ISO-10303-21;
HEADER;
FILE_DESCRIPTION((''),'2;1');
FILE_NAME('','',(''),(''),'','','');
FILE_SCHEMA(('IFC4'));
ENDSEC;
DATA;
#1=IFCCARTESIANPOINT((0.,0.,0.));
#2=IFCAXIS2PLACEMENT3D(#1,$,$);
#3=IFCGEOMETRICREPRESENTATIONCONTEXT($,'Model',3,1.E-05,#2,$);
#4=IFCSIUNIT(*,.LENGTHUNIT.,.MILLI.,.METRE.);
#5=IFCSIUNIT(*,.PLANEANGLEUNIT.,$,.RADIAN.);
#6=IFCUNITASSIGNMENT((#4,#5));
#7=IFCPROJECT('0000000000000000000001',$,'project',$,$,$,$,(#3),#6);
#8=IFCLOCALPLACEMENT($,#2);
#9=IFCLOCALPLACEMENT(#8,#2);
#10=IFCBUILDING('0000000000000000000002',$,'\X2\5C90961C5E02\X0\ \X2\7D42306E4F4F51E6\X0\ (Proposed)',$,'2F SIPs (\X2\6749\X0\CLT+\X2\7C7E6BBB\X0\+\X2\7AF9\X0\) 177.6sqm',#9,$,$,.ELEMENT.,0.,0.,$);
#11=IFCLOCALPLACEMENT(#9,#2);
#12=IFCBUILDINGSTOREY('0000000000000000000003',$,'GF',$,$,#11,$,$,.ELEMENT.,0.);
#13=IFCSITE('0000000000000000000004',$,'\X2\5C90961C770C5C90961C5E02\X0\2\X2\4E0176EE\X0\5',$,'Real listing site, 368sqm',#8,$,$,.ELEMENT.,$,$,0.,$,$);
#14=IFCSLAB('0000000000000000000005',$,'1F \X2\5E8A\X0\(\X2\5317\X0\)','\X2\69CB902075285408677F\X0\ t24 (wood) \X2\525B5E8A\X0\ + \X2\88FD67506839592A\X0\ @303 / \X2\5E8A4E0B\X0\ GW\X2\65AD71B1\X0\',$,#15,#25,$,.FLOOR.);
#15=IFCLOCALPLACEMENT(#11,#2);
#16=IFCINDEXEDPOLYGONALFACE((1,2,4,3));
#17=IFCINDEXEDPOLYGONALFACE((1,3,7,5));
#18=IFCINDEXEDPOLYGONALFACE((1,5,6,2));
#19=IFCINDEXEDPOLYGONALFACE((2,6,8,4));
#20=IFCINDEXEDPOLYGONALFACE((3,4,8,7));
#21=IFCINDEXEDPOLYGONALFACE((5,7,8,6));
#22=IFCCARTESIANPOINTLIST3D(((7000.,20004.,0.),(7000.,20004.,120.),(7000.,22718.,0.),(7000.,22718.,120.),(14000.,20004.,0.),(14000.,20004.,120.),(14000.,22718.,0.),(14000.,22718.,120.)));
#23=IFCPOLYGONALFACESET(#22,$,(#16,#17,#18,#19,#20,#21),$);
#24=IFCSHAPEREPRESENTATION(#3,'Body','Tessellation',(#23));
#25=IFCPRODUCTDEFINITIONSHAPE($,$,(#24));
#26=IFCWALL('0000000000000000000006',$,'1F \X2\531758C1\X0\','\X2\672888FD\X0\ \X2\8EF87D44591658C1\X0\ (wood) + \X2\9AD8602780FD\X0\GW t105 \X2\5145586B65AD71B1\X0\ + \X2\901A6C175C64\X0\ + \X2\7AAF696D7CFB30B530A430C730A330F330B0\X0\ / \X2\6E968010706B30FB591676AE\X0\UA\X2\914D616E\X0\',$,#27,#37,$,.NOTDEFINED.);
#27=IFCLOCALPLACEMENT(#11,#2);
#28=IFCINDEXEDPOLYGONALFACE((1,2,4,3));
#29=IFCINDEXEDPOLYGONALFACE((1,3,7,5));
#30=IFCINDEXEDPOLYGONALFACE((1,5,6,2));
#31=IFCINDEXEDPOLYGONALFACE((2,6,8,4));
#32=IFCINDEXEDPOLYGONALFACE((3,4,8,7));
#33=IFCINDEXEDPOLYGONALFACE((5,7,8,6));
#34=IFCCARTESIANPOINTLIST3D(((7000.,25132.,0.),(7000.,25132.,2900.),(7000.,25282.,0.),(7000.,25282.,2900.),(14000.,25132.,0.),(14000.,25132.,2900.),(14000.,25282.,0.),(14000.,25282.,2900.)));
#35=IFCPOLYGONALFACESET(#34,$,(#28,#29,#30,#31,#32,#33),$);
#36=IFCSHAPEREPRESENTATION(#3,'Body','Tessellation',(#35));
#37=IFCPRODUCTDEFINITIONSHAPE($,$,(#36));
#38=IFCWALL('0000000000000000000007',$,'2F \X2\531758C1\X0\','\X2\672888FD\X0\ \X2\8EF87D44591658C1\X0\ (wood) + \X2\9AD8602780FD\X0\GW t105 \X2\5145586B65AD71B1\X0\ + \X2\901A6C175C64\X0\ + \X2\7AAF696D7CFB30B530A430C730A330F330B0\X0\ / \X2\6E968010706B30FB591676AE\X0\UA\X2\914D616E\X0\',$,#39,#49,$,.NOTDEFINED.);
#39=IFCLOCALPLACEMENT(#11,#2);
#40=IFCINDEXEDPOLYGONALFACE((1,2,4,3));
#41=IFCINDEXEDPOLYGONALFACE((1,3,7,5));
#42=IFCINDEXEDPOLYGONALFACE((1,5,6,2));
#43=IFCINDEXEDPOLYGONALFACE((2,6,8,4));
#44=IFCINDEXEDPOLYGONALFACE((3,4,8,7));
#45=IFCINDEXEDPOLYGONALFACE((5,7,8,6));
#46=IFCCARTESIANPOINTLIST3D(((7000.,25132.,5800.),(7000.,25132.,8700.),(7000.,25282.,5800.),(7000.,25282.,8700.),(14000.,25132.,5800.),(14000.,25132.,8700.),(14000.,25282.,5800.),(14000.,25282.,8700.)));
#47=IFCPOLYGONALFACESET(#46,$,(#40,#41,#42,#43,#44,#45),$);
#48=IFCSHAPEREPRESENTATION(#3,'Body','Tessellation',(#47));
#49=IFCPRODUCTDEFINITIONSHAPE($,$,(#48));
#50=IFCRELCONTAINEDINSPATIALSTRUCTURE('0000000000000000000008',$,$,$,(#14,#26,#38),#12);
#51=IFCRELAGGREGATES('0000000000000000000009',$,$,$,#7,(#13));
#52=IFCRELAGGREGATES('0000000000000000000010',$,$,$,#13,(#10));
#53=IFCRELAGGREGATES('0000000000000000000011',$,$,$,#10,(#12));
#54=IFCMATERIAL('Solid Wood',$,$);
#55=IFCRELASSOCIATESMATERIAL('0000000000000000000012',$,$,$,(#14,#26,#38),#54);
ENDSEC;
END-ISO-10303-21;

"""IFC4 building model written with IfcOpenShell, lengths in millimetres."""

from ifc_helpers import new_model, si_unit, frame, frame_2d, origin, place, context, project, spatial, rectangle, extrude, material, element, save


model = new_model("IFC4")

# Units and contexts
model_context = context("Model", 3, precision=1e-05, world=origin())
ifc_project = project(units=[si_unit("LENGTHUNIT", "METRE", prefix="MILLI"), si_unit("PLANEANGLEUNIT", "RADIAN")], contexts=[model_context])

# Site, building, storey
site_placement = place(None, origin())
site = spatial("IfcSite", under=ifc_project, at=site_placement, Name="岐阜県岐阜市2丁目5", ObjectType="Real listing site, 368sqm", CompositionType="ELEMENT", RefElevation=0.0)
building_placement = place(site_placement, origin())
building = spatial("IfcBuilding", under=site, at=building_placement, Name="岐阜市 終の住処 (Proposed)", ObjectType="2F SIPs (杉CLT+籾殻+竹) 177.6sqm", CompositionType="ELEMENT", ElevationOfRefHeight=0.0, ElevationOfTerrain=0.0)
storey_placement = place(building_placement, origin())
storey = spatial("IfcBuildingStorey", under=building, at=storey_placement, Name="GF", CompositionType="ELEMENT", Elevation=0.0)

# Slab
ifc_material_1 = material(Name="Solid Wood")
slab_1_placement = place(storey_placement, frame((3500.0, 10002.0, 0.0)))
element("IfcSlab", 1, at=slab_1_placement, inside=storey, material=ifc_material_1, Name="1F 床(北)", Description="構造用合板 t24 (wood) 剛床 + 製材根太 @303 / 床下 GW断熱", PredefinedType="FLOOR", context=model_context, shape_type="SweptSolid", body=[
    extrude(rectangle(XDim=7000.0, YDim=2714.0, at=frame_2d((3500.0, 1357.0))), frame((3500.0, 10002.0, 0.0)), (0.0, 0.0, 1.0), 120.0),
])

# Wall
wall_1_placement = place(storey_placement, frame((3500.0, 12566.0, 0.0)))
element("IfcWall", 2, at=wall_1_placement, inside=storey, material=ifc_material_1, Name="1F 北壁", Description="木製 軸組外壁 (wood) + 高性能GW t105 充填断熱 + 通気層 + 窯業系サイディング / 準耐火・外皮UA配慮", PredefinedType="NOTDEFINED", context=model_context, shape_type="SweptSolid", body=[
    extrude(rectangle(XDim=7000.0, YDim=150.0, at=frame_2d((3500.0, 75.0))), frame((3500.0, 12566.0, 0.0)), (0.0, 0.0, 1.0), 2900.0),
])

# Wall
wall_2_placement = place(storey_placement, frame((3500.0, 12566.0, 2900.0)))
element("IfcWall", 3, at=wall_2_placement, inside=storey, material=ifc_material_1, Name="2F 北壁", Description="木製 軸組外壁 (wood) + 高性能GW t105 充填断熱 + 通気層 + 窯業系サイディング / 準耐火・外皮UA配慮", PredefinedType="NOTDEFINED", context=model_context, shape_type="SweptSolid", body=[
    extrude(rectangle(XDim=7000.0, YDim=150.0, at=frame_2d((3500.0, 75.0))), frame((3500.0, 12566.0, 2900.0)), (0.0, 0.0, 1.0), 2900.0),
])

save(model, "model.ifc")
